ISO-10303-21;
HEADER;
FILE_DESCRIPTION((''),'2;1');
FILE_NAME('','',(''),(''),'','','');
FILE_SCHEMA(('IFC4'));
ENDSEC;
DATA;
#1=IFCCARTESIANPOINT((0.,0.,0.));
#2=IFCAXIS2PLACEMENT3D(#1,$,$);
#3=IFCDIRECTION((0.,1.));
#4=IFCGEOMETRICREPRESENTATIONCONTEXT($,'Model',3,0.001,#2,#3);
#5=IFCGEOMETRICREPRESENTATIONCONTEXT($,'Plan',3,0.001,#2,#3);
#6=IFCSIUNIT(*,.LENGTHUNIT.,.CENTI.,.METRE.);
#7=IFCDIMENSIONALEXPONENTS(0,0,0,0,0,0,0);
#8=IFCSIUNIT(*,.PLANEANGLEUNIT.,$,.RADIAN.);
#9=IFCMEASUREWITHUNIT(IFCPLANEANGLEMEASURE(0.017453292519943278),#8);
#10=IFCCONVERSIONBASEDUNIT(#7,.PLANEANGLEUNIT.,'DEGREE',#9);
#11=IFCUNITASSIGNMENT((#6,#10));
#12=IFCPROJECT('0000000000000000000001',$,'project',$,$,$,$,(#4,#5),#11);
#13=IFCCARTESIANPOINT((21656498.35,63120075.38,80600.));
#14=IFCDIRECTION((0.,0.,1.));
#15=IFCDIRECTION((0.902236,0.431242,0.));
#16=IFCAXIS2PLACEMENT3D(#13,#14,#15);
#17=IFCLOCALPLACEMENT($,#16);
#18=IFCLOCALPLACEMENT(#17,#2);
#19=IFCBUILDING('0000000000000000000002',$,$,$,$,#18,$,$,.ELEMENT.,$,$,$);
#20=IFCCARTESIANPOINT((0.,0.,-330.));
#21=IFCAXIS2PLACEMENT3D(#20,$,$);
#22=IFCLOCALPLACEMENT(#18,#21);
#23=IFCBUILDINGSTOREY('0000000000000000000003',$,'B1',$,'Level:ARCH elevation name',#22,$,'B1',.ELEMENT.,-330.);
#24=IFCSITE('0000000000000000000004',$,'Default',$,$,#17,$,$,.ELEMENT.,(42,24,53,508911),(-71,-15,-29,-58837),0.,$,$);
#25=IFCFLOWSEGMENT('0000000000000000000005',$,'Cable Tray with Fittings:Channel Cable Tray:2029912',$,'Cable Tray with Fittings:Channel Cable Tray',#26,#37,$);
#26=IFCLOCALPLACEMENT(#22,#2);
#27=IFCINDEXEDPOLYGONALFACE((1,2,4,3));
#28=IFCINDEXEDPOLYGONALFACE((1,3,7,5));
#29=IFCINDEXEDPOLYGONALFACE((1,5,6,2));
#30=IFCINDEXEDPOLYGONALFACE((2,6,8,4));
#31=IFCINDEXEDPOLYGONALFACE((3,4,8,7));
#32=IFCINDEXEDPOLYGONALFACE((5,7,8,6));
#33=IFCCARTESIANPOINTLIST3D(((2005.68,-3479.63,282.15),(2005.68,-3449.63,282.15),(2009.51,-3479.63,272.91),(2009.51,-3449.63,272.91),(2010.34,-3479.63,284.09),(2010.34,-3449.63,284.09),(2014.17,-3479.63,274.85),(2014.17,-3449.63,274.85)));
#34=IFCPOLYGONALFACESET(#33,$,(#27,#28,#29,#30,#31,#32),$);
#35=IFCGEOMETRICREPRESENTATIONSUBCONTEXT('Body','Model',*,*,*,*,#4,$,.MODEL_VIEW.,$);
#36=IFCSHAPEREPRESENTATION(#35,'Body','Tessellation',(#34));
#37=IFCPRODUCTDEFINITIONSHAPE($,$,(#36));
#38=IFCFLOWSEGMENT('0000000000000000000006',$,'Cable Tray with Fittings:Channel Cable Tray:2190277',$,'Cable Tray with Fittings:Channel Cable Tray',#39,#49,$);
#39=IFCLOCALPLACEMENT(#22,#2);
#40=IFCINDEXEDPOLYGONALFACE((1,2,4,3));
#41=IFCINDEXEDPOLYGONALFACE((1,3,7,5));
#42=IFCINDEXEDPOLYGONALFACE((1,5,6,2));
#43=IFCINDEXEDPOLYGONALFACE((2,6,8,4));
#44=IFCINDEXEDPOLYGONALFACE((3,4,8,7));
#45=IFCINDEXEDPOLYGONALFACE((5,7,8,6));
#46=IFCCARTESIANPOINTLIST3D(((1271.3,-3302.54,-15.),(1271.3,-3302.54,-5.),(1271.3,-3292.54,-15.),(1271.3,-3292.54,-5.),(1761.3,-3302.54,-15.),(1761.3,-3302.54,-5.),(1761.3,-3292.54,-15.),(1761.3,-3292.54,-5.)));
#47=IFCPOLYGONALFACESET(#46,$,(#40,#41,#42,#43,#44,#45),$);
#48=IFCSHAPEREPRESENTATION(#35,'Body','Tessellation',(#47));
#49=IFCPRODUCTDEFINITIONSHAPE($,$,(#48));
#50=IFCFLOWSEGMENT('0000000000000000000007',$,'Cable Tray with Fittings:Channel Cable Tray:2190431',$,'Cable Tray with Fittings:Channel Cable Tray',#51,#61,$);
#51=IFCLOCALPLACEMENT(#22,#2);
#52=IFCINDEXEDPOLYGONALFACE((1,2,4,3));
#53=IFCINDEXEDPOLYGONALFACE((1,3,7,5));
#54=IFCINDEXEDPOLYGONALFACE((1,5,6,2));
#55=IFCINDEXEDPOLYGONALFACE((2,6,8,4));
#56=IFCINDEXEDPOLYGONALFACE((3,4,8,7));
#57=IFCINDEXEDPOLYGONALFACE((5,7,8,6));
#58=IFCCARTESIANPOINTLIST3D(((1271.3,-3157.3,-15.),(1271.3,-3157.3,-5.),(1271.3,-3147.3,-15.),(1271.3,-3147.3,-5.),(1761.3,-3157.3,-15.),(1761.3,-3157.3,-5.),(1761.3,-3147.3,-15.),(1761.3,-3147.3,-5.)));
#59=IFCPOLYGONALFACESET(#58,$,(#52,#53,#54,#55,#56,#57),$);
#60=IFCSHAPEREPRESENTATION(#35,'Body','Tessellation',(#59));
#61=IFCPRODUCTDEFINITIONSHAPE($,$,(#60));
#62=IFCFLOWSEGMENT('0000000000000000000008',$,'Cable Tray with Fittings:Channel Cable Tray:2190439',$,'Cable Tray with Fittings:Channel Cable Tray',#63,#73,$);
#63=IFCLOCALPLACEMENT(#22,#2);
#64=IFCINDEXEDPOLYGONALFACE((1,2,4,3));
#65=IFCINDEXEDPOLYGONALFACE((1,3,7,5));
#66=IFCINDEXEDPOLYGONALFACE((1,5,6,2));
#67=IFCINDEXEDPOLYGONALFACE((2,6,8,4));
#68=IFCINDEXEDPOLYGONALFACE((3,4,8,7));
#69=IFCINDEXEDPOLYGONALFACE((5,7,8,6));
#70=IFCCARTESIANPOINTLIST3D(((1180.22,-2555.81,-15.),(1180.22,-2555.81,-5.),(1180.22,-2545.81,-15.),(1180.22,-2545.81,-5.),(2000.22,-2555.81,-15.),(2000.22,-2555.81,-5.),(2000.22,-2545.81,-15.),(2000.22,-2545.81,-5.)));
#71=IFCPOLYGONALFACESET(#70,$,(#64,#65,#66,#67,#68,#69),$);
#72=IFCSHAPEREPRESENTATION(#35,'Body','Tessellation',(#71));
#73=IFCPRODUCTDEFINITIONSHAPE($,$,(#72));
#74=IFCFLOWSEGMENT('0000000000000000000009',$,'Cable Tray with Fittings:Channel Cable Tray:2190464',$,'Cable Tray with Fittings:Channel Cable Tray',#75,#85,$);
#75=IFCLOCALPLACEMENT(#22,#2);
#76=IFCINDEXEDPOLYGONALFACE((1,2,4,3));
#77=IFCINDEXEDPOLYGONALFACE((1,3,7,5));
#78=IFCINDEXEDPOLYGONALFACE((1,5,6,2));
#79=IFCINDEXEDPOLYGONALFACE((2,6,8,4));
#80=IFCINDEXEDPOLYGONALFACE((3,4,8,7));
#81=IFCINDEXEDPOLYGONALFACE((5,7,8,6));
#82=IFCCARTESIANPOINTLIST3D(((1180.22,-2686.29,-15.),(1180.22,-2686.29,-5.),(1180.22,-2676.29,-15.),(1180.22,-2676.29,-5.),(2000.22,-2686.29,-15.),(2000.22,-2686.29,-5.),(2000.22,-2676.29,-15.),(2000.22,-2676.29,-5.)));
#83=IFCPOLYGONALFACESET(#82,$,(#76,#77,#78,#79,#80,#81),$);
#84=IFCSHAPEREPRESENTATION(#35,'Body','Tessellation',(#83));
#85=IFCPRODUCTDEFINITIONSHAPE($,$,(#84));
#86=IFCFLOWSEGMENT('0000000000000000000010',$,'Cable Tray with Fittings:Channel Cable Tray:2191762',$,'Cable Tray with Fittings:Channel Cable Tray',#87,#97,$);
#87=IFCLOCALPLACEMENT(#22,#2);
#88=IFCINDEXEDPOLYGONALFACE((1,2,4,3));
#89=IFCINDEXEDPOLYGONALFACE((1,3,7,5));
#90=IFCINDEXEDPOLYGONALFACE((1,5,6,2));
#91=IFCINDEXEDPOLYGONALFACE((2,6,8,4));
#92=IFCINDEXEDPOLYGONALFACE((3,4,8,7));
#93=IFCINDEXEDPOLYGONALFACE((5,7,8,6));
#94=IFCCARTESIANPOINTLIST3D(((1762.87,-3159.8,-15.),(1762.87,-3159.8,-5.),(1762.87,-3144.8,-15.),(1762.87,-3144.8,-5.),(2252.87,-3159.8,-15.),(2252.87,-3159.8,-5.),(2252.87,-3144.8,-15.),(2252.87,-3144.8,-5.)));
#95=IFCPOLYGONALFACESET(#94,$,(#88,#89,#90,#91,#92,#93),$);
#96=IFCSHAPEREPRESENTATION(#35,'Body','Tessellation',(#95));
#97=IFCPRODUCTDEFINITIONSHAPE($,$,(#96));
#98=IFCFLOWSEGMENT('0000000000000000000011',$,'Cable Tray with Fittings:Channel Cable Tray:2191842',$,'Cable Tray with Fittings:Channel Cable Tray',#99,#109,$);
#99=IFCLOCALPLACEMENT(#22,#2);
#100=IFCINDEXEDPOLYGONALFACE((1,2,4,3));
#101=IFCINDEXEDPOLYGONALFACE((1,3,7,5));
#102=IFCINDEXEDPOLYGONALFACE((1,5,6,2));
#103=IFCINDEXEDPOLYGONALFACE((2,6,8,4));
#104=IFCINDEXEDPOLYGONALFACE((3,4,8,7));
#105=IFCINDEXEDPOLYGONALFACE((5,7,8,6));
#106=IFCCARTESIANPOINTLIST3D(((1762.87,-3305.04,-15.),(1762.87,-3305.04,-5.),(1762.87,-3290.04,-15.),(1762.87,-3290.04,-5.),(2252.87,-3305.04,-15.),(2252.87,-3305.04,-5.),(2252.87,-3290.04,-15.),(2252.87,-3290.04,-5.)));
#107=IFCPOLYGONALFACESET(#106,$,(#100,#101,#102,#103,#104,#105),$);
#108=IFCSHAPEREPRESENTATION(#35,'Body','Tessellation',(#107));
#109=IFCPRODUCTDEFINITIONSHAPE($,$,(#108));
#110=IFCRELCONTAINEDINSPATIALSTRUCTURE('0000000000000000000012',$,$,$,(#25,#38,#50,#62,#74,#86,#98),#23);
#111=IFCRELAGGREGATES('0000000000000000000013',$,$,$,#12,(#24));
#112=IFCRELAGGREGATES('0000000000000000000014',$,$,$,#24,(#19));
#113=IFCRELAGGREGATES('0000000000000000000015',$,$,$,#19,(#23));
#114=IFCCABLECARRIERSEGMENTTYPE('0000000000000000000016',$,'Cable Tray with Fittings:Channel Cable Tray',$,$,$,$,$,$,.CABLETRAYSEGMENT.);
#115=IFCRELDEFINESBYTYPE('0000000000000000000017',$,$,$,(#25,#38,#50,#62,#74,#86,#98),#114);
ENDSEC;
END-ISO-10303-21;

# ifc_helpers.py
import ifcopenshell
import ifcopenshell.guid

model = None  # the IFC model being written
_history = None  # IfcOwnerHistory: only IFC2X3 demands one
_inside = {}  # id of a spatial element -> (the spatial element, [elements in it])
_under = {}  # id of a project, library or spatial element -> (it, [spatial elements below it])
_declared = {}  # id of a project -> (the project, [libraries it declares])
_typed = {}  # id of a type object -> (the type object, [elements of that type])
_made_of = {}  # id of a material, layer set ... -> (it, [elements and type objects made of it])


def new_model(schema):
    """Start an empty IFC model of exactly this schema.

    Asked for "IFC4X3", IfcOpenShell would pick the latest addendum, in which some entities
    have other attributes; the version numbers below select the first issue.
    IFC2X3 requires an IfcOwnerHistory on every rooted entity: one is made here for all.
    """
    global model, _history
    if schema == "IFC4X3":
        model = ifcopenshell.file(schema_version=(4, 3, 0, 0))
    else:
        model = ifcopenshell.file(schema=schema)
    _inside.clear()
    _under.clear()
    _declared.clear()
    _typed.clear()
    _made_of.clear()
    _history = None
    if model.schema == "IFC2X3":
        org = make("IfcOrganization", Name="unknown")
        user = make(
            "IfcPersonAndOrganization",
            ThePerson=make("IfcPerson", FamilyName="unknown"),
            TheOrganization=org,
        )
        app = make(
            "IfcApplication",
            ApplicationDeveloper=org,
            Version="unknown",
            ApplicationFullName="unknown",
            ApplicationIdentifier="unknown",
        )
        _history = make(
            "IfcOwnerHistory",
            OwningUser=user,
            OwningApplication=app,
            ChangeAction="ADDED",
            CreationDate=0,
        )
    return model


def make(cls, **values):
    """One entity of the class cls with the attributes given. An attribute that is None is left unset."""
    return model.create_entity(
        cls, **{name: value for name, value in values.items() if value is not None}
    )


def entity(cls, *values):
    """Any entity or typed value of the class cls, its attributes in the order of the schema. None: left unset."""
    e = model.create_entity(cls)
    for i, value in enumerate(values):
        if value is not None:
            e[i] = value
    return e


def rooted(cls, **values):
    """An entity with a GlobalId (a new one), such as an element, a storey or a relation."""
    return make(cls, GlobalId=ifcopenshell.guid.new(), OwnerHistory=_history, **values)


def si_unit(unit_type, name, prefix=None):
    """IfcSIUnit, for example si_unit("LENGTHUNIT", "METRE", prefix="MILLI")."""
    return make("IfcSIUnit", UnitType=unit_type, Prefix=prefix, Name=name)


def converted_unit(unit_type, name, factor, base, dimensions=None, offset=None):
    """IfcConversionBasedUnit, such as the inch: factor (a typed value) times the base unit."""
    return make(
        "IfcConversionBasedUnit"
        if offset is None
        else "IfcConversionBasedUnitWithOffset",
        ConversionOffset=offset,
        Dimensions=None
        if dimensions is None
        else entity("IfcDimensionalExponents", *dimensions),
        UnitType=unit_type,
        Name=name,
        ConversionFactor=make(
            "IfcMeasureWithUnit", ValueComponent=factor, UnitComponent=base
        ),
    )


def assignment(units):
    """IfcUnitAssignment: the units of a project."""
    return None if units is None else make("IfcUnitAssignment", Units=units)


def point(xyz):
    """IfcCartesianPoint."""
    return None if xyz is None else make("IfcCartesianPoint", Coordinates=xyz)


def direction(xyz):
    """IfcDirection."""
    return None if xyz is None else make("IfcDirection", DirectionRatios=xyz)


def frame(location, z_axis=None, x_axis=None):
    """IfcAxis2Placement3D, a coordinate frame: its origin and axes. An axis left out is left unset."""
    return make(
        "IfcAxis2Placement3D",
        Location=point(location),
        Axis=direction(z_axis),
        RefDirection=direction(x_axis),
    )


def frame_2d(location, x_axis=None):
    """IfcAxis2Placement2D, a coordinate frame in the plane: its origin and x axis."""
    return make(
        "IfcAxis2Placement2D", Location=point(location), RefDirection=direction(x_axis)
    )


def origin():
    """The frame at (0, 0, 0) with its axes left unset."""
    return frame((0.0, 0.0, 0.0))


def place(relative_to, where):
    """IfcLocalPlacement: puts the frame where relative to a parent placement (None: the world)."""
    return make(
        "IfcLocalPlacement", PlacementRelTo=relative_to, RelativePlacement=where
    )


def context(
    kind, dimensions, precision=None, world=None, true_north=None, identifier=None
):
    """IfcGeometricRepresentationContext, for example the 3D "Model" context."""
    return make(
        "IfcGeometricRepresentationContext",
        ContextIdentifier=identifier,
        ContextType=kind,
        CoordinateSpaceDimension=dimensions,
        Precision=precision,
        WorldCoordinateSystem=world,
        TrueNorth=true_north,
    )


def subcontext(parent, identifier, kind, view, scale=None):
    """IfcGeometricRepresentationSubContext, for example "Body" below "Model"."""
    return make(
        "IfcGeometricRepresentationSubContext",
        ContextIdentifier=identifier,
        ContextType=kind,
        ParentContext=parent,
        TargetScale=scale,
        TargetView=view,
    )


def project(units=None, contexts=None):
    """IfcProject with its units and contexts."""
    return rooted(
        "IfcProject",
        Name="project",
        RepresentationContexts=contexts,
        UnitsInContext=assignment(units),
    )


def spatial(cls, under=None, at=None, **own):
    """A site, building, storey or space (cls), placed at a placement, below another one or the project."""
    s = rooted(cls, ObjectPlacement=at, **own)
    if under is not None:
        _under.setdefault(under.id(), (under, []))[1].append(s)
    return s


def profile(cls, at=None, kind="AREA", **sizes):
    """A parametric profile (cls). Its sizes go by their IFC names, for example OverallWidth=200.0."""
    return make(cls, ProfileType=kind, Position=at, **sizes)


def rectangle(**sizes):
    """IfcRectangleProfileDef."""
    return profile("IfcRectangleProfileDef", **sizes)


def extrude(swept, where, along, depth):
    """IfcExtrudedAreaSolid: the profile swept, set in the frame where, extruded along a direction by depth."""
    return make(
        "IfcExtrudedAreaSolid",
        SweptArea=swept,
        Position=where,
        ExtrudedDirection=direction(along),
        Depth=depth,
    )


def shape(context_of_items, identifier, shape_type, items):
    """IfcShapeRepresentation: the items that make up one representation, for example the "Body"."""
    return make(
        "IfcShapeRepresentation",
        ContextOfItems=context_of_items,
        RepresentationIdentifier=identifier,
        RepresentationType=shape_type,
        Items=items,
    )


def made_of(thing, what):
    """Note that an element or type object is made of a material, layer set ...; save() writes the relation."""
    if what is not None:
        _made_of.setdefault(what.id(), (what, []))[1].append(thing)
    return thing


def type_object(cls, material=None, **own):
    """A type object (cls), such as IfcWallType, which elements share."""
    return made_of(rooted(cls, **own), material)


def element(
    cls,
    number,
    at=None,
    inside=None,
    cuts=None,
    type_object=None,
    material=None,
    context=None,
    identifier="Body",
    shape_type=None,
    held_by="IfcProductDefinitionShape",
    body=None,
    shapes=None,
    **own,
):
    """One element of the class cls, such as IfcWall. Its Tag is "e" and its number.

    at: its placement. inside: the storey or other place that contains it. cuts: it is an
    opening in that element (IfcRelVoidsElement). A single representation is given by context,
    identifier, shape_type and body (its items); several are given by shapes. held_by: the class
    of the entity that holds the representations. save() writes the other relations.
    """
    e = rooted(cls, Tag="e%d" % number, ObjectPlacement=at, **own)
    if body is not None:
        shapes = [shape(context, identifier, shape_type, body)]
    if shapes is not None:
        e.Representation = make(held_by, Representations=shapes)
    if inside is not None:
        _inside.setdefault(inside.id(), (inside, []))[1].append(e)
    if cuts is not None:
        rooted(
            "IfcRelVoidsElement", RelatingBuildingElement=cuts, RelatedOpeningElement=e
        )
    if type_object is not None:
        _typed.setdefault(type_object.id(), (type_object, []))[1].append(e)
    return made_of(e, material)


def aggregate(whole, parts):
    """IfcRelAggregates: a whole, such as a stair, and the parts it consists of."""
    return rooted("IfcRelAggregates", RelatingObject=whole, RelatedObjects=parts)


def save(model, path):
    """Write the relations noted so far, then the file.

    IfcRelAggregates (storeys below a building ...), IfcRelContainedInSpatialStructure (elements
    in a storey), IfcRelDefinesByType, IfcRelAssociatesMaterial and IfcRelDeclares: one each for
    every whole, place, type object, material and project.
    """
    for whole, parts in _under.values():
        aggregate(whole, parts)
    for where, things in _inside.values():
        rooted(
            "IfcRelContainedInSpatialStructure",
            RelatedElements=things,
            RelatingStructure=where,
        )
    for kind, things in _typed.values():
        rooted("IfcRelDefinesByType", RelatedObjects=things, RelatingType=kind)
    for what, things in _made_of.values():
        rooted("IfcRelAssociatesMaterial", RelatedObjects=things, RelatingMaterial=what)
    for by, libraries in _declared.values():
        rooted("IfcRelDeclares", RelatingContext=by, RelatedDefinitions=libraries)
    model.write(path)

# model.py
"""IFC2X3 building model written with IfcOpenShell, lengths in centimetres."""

from ifc_helpers import new_model, entity, si_unit, converted_unit, direction, frame, frame_2d, origin, place, context, subcontext, project, spatial, rectangle, extrude, type_object, element, save


model = new_model("IFC2X3")

# Units and contexts
model_context = context("Model", 3, precision=0.001, world=origin(), true_north=direction((0.0, 1.0)))
plan_context = context("Plan", 3, precision=0.001, world=origin(), true_north=direction((0.0, 1.0)))
body_context = subcontext(model_context, "Body", "Model", "MODEL_VIEW")
ifc_project = project(units=[si_unit("LENGTHUNIT", "METRE", prefix="CENTI"), converted_unit("PLANEANGLEUNIT", "DEGREE", entity("IfcPlaneAngleMeasure", 0.017453292519943278), si_unit("PLANEANGLEUNIT", "RADIAN"), dimensions=[0, 0, 0, 0, 0, 0, 0])], contexts=[model_context, plan_context])

# Site, building, storey
site_placement = place(None, frame((21656498.35, 63120075.38, 80600.0), z_axis=(0.0, 0.0, 1.0), x_axis=(0.902236, 0.431242, 0.0)))
site = spatial("IfcSite", under=ifc_project, at=site_placement, Name="Default", CompositionType="ELEMENT", RefLatitude=(42, 24, 53, 508911), RefLongitude=(-71, -15, -29, -58837), RefElevation=0.0)
building_placement = place(site_placement, origin())
building = spatial("IfcBuilding", under=site, at=building_placement, CompositionType="ELEMENT")
storey_placement = place(building_placement, frame((0.0, 0.0, -330.0)))
storey = spatial("IfcBuildingStorey", under=building, at=storey_placement, Name="B1", ObjectType="Level:ARCH elevation name", LongName="B1", CompositionType="ELEMENT", Elevation=-330.0)

# Flow segments
cable_carrier_segment_type = type_object("IfcCableCarrierSegmentType", Name="Cable Tray with Fittings:Channel Cable Tray", PredefinedType="CABLETRAYSEGMENT")
flow_segment_1_placement = place(storey_placement, origin())
element("IfcFlowSegment", 1, at=flow_segment_1_placement, inside=storey, type_object=cable_carrier_segment_type, Name="Cable Tray with Fittings:Channel Cable Tray:2029912", ObjectType="Cable Tray with Fittings:Channel Cable Tray", context=body_context, shape_type="SweptSolid", body=[
    extrude(rectangle(XDim=10.0, YDim=5.05, at=frame_2d((0.0, 0.0), x_axis=(0.0, 1.0))), frame((2009.92, -3479.63, 278.5), z_axis=(0.0, 1.0, 0.0), x_axis=(0.92388, 0.0, 0.382683)), (0.0, 0.0, 1.0), 30.0),
])
flow_segment_2_placement = place(storey_placement, origin())
element("IfcFlowSegment", 2, at=flow_segment_2_placement, inside=storey, type_object=cable_carrier_segment_type, Name="Cable Tray with Fittings:Channel Cable Tray:2190277", ObjectType="Cable Tray with Fittings:Channel Cable Tray", context=body_context, shape_type="SweptSolid", body=[
    extrude(rectangle(XDim=490.0, YDim=10.0, at=frame_2d((0.0, 0.0), x_axis=(1.0, 0.0))), frame((1516.3, -3297.54, -15.0)), (0.0, 0.0, 1.0), 10.0),
])
flow_segment_3_placement = place(storey_placement, origin())
element("IfcFlowSegment", 3, at=flow_segment_3_placement, inside=storey, type_object=cable_carrier_segment_type, Name="Cable Tray with Fittings:Channel Cable Tray:2190431", ObjectType="Cable Tray with Fittings:Channel Cable Tray", context=body_context, shape_type="SweptSolid", body=[
    extrude(rectangle(XDim=490.0, YDim=10.0, at=frame_2d((0.0, 0.0), x_axis=(1.0, 0.0))), frame((1516.3, -3152.3, -15.0)), (0.0, 0.0, 1.0), 10.0),
])
flow_segment_4_placement = place(storey_placement, origin())
element("IfcFlowSegment", 4, at=flow_segment_4_placement, inside=storey, type_object=cable_carrier_segment_type, Name="Cable Tray with Fittings:Channel Cable Tray:2190439", ObjectType="Cable Tray with Fittings:Channel Cable Tray", context=body_context, shape_type="SweptSolid", body=[
    extrude(rectangle(XDim=820.0, YDim=10.0, at=frame_2d((0.0, 0.0), x_axis=(1.0, 0.0))), frame((1590.22, -2550.81, -15.0)), (0.0, 0.0, 1.0), 10.0),
])
flow_segment_5_placement = place(storey_placement, origin())
element("IfcFlowSegment", 5, at=flow_segment_5_placement, inside=storey, type_object=cable_carrier_segment_type, Name="Cable Tray with Fittings:Channel Cable Tray:2190464", ObjectType="Cable Tray with Fittings:Channel Cable Tray", context=body_context, shape_type="SweptSolid", body=[
    extrude(rectangle(XDim=820.0, YDim=10.0, at=frame_2d((0.0, 0.0), x_axis=(1.0, 0.0))), frame((1590.22, -2681.29, -15.0)), (0.0, 0.0, 1.0), 10.0),
])
flow_segment_6_placement = place(storey_placement, origin())
element("IfcFlowSegment", 6, at=flow_segment_6_placement, inside=storey, type_object=cable_carrier_segment_type, Name="Cable Tray with Fittings:Channel Cable Tray:2191762", ObjectType="Cable Tray with Fittings:Channel Cable Tray", context=body_context, shape_type="SweptSolid", body=[
    extrude(rectangle(XDim=490.0, YDim=15.0, at=frame_2d((0.0, 0.0), x_axis=(1.0, 0.0))), frame((2007.87, -3152.3, -15.0)), (0.0, 0.0, 1.0), 10.0),
])
flow_segment_7_placement = place(storey_placement, origin())
element("IfcFlowSegment", 7, at=flow_segment_7_placement, inside=storey, type_object=cable_carrier_segment_type, Name="Cable Tray with Fittings:Channel Cable Tray:2191842", ObjectType="Cable Tray with Fittings:Channel Cable Tray", context=body_context, shape_type="SweptSolid", body=[
    extrude(rectangle(XDim=490.0, YDim=15.0, at=frame_2d((0.0, 0.0), x_axis=(1.0, 0.0))), frame((2007.87, -3297.54, -15.0)), (0.0, 0.0, 1.0), 10.0),
])

save(model, "model.ifc")
